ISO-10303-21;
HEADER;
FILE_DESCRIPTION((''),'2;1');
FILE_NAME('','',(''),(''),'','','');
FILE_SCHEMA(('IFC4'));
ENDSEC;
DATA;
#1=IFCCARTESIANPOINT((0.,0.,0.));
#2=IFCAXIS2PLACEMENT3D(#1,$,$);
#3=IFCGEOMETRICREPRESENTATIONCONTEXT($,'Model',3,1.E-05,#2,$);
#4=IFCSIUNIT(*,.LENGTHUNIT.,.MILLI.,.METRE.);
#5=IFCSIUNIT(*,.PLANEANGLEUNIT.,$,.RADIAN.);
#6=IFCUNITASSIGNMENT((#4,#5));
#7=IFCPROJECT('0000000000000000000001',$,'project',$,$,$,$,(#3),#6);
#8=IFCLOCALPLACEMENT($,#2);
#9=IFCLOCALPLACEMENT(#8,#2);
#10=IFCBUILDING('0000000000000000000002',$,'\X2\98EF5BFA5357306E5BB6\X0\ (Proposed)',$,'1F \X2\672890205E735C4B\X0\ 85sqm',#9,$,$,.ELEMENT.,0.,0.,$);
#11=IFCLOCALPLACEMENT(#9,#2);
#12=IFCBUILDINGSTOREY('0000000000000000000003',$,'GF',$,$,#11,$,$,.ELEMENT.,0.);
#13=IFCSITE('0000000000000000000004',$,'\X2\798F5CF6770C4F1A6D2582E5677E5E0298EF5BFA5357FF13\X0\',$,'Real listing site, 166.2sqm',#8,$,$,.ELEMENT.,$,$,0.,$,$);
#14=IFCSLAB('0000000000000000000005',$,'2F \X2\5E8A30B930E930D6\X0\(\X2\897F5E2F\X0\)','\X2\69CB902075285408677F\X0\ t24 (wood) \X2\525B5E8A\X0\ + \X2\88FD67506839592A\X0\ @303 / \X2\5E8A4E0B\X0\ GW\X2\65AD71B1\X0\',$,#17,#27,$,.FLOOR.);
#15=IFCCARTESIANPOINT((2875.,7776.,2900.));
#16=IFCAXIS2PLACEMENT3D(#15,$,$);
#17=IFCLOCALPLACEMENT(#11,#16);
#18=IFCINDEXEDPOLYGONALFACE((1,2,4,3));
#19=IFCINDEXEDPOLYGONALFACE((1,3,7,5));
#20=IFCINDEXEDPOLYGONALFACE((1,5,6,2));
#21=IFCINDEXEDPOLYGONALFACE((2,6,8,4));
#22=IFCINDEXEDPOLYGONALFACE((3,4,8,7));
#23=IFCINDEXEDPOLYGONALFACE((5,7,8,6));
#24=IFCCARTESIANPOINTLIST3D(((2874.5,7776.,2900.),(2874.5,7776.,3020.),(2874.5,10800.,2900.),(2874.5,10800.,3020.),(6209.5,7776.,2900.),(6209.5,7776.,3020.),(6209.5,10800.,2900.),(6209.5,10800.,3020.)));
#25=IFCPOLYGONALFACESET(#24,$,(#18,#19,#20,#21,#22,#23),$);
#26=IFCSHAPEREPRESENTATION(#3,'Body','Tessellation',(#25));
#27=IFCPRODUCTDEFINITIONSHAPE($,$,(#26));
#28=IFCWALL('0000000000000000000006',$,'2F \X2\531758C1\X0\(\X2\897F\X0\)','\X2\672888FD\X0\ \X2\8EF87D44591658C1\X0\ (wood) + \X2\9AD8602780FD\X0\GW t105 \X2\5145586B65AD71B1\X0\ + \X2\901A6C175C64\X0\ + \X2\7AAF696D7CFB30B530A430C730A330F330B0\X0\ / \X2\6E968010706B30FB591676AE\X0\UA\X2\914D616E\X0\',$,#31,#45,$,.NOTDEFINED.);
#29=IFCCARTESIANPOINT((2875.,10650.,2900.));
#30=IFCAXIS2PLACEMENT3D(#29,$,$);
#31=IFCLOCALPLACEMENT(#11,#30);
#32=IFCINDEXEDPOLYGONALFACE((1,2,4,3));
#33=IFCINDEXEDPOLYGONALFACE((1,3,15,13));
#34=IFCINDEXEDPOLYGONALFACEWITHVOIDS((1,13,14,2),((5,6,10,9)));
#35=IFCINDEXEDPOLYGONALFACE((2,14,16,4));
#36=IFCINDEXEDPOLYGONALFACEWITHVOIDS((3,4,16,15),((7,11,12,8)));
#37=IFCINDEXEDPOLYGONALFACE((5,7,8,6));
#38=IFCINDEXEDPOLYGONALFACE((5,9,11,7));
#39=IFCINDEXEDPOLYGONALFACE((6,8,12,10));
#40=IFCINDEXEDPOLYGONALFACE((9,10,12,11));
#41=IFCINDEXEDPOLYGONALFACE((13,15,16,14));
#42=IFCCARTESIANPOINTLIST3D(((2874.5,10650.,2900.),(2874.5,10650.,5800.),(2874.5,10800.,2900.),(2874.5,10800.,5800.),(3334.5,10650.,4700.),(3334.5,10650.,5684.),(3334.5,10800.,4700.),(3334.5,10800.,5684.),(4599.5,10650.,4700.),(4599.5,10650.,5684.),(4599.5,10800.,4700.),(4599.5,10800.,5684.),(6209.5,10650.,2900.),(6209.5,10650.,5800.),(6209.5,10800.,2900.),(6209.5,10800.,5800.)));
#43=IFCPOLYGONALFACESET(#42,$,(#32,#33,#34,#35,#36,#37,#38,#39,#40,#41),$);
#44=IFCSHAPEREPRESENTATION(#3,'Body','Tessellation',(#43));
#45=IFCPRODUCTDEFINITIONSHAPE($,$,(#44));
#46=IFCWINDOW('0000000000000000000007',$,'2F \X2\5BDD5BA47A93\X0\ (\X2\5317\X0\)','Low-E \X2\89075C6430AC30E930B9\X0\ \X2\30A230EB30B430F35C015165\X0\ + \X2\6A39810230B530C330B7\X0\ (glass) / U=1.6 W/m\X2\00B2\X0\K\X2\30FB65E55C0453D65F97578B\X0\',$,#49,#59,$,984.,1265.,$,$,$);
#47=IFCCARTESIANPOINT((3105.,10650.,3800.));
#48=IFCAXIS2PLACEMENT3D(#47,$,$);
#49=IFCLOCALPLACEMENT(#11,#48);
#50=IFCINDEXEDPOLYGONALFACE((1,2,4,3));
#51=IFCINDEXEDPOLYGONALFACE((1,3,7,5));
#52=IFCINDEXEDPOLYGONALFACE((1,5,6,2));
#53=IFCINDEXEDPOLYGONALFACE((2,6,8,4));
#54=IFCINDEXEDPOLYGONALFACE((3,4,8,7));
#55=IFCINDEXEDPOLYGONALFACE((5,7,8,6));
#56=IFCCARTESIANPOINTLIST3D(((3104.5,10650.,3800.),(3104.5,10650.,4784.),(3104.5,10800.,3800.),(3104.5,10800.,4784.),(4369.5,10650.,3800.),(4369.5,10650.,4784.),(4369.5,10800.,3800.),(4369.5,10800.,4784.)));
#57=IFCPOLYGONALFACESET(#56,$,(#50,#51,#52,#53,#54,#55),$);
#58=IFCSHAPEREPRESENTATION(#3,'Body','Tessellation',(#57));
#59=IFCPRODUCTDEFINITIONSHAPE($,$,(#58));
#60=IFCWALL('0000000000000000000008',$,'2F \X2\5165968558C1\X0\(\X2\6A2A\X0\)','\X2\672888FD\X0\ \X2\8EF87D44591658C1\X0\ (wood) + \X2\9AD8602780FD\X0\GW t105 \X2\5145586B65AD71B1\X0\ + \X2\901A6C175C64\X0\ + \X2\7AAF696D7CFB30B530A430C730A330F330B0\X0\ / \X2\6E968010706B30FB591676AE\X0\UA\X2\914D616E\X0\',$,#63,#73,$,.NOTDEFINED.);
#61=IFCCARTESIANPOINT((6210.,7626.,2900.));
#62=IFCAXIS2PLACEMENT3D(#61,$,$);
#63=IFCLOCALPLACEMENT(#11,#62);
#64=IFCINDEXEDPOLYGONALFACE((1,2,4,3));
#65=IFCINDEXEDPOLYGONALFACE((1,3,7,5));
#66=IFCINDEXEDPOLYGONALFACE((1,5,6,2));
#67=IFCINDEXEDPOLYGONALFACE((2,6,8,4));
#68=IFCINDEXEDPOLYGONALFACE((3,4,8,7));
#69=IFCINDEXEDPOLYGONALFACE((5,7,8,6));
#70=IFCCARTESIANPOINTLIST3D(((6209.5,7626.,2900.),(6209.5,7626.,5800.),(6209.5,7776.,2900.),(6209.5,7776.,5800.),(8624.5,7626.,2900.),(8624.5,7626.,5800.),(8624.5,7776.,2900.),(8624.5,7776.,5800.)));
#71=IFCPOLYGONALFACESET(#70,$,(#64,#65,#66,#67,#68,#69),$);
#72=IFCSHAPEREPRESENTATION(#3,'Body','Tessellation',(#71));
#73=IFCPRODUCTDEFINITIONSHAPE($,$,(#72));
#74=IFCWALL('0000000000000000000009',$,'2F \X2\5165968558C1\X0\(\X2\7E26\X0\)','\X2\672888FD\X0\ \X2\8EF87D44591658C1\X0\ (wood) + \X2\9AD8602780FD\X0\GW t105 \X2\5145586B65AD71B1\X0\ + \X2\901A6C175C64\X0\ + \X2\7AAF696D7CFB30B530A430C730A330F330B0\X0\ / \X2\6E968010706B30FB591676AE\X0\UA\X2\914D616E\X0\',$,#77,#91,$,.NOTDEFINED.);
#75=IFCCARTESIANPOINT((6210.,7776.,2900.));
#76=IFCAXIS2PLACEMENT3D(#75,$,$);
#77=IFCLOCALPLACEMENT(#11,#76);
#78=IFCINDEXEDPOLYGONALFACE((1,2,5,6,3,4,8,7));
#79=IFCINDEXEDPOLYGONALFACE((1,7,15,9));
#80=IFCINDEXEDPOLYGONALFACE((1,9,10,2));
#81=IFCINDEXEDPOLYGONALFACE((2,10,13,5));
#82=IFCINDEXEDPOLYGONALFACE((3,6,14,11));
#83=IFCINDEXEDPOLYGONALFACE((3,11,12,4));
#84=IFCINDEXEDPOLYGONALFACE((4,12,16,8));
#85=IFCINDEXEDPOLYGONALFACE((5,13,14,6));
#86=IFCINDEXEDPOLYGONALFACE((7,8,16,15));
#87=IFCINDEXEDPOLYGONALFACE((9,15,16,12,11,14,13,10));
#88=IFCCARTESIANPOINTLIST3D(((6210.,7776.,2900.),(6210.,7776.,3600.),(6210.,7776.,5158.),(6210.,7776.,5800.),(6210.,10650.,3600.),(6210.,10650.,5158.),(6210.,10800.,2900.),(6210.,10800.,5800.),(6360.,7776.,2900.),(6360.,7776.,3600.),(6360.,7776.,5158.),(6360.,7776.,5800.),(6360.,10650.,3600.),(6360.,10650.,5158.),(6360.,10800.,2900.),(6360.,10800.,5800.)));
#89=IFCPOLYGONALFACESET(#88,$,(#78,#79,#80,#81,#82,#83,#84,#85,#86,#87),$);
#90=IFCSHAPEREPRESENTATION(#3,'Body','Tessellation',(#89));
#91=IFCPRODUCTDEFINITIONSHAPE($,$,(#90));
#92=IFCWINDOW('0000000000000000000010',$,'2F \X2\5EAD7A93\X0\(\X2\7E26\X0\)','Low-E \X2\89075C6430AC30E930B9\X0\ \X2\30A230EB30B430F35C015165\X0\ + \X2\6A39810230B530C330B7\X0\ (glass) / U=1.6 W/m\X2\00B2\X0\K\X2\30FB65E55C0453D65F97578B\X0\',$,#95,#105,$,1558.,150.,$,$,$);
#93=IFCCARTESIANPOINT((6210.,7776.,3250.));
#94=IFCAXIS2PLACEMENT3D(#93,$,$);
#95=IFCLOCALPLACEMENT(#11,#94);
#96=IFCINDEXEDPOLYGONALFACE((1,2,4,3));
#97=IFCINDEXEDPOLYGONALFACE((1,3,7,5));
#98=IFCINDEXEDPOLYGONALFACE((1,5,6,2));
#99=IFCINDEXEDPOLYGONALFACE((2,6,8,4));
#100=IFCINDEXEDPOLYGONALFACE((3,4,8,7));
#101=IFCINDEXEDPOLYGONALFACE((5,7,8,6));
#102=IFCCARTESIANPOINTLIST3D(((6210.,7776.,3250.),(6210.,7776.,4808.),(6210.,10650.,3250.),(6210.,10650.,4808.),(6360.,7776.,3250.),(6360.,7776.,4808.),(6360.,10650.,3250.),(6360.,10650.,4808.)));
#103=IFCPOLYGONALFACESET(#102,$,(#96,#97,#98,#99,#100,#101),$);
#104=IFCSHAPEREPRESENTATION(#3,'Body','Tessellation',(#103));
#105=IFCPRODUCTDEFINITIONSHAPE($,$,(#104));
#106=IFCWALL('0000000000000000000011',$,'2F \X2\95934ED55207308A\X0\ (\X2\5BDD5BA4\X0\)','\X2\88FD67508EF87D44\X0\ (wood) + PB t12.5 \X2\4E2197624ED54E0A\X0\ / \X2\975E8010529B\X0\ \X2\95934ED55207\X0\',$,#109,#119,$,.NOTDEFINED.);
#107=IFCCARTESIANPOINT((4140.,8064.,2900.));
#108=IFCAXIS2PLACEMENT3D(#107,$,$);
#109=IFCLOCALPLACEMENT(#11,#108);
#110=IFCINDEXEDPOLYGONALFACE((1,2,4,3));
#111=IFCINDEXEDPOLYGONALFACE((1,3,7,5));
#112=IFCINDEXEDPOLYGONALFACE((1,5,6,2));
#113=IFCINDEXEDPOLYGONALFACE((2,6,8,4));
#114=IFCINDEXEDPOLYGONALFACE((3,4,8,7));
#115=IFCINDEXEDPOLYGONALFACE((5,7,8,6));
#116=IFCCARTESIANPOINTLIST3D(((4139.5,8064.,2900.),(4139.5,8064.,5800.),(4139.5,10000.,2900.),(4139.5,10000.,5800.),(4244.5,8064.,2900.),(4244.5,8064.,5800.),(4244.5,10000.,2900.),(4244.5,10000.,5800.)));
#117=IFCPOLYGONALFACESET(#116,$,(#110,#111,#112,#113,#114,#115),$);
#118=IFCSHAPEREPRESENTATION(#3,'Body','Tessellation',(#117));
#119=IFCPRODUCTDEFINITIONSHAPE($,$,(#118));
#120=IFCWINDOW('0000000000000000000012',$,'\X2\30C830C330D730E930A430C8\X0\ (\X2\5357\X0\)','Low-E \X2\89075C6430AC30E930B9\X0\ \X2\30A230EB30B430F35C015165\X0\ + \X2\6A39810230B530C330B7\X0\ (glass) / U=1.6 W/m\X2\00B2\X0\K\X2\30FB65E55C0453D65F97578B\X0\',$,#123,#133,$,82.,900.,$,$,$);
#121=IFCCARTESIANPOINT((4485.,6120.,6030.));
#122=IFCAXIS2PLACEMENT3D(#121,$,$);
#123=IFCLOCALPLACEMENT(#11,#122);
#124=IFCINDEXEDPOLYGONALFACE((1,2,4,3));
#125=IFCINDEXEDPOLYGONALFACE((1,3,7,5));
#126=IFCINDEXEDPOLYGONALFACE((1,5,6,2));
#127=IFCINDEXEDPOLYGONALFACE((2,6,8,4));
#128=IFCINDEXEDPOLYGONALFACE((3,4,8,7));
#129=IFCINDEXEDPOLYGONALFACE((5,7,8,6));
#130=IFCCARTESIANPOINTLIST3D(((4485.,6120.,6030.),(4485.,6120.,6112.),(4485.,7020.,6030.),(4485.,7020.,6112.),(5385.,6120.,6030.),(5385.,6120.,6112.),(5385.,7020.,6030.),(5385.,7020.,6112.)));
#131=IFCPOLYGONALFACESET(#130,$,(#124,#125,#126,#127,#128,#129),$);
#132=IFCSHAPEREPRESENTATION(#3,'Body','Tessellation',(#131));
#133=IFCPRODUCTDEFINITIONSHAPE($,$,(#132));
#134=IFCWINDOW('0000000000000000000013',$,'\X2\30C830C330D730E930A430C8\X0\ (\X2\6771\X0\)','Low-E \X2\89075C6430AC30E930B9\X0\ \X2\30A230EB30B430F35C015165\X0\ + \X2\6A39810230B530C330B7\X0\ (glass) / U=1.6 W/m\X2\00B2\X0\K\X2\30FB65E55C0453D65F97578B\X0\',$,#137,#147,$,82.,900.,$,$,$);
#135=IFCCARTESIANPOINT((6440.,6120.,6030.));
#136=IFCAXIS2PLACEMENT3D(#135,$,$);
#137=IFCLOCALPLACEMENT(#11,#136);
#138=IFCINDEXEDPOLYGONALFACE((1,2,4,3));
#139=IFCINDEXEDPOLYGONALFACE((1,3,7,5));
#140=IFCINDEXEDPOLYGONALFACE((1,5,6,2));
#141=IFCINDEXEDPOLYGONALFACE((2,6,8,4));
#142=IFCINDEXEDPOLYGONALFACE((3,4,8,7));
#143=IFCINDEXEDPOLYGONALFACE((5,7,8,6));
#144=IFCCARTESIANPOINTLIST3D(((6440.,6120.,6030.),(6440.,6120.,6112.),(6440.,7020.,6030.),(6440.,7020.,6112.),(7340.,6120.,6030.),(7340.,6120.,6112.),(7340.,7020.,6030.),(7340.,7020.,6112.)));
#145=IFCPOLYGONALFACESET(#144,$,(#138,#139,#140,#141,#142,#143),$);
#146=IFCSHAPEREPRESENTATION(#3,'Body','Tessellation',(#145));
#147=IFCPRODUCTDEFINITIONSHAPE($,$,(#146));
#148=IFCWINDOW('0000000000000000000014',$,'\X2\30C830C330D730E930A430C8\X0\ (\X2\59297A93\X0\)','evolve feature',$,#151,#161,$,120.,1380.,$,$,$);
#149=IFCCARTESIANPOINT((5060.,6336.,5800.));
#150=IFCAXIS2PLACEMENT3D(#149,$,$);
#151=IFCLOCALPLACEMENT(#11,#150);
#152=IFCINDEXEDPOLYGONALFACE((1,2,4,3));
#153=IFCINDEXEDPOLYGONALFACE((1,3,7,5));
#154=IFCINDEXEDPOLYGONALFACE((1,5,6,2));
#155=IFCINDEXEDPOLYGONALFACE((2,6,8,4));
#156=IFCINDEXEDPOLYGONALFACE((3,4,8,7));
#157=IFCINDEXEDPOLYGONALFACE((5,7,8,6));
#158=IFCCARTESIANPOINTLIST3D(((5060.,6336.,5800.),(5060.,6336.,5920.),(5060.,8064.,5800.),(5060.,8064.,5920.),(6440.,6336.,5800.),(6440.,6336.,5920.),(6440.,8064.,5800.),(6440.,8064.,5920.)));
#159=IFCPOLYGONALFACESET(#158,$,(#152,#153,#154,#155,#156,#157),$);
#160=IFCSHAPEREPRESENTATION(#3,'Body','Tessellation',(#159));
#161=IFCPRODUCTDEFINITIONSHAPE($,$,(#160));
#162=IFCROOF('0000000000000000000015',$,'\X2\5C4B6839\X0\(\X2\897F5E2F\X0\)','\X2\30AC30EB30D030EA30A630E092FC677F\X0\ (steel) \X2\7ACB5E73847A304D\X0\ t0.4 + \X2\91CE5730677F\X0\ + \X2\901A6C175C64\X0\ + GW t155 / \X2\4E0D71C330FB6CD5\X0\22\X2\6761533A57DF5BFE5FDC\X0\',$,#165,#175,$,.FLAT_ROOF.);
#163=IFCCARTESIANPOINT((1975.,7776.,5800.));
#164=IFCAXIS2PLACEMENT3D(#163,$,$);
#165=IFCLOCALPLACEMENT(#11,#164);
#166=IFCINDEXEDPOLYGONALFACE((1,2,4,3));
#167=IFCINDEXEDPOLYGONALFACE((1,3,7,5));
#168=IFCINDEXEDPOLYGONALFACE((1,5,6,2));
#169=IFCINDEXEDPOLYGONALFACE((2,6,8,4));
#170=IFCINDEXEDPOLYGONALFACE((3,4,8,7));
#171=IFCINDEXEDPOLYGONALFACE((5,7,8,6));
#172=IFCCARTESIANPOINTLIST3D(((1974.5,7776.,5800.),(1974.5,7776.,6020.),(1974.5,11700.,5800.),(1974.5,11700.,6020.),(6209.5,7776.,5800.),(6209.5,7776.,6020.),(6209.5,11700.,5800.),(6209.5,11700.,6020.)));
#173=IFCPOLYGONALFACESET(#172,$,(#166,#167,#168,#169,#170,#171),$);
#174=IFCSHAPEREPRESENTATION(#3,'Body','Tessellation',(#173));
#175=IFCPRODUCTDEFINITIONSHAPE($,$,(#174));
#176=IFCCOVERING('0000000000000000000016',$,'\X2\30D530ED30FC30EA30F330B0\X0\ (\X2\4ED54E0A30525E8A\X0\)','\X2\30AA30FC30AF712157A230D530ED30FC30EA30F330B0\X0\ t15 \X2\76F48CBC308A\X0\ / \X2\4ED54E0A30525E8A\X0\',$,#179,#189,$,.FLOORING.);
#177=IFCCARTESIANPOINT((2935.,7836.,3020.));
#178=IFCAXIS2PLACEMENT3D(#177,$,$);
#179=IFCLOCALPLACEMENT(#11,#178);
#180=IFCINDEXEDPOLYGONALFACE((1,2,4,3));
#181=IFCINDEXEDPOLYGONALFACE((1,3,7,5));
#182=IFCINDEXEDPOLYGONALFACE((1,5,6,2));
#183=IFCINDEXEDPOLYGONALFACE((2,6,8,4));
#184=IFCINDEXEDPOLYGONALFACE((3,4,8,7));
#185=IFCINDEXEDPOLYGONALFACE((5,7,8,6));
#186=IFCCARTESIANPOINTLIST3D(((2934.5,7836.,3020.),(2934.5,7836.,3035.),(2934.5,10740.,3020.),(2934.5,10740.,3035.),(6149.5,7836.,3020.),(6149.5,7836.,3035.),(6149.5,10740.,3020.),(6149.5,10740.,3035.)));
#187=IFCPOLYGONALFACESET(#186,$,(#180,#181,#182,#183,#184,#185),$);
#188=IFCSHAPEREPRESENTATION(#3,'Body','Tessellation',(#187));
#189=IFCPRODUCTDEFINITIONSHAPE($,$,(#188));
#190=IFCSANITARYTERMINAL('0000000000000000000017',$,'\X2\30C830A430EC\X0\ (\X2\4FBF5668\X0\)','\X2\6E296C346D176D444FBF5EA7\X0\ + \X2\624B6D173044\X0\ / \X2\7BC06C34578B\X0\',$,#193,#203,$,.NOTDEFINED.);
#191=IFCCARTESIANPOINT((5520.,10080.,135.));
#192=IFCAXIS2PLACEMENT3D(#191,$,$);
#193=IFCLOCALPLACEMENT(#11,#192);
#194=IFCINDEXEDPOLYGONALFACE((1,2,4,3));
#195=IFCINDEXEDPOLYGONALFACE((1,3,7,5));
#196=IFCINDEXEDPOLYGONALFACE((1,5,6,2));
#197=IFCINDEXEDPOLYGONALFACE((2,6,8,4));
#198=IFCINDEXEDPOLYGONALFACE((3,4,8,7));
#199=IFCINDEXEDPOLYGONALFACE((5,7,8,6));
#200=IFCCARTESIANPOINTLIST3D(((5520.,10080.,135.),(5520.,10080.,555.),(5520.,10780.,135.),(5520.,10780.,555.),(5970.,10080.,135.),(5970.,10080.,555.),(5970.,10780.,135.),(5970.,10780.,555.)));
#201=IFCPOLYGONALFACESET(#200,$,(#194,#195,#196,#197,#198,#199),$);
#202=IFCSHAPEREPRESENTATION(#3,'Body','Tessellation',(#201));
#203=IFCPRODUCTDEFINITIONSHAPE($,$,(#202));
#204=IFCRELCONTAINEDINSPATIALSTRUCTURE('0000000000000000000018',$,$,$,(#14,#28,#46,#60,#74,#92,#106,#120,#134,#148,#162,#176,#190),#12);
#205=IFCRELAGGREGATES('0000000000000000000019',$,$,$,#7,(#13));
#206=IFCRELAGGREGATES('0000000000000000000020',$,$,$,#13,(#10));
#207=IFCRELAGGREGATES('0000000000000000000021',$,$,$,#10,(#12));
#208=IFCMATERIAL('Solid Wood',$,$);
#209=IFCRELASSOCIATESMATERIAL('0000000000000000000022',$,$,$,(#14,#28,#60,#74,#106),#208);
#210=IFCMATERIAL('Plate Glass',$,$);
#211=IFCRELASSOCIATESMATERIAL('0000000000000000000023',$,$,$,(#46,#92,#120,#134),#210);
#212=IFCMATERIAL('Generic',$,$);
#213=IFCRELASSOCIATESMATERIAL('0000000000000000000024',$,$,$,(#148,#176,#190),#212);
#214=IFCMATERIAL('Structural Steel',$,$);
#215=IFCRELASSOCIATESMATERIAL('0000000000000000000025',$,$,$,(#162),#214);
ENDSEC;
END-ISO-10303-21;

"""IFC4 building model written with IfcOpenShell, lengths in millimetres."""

from ifc_helpers import new_model, si_unit, frame, frame_2d, origin, place, context, project, spatial, rectangle, extrude, material, element, fill, save


model = new_model("IFC4")

# Units and contexts
model_context = context("Model", 3, precision=1e-05, world=origin())
ifc_project = project(units=[si_unit("LENGTHUNIT", "METRE", prefix="MILLI"), si_unit("PLANEANGLEUNIT", "RADIAN")], contexts=[model_context])

# Site, building, storey
site_placement = place(None, origin())
site = spatial("IfcSite", under=ifc_project, at=site_placement, Name="福島県会津若松市飯寺南３", ObjectType="Real listing site, 166.2sqm", CompositionType="ELEMENT", RefElevation=0.0)
building_placement = place(site_placement, origin())
building = spatial("IfcBuilding", under=site, at=building_placement, Name="飯寺南の家 (Proposed)", ObjectType="1F 木造平屋 85sqm", CompositionType="ELEMENT", ElevationOfRefHeight=0.0, ElevationOfTerrain=0.0)
storey_placement = place(building_placement, origin())
storey = spatial("IfcBuildingStorey", under=building, at=storey_placement, Name="GF", CompositionType="ELEMENT", Elevation=0.0)

# Slab
ifc_material_1 = material(Name="Solid Wood")
slab_placement = place(storey_placement, frame((2875.0, 7776.0, 2900.0)))
element("IfcSlab", 1, at=slab_placement, inside=storey, material=ifc_material_1, Name="2F 床スラブ(西帯)", Description="構造用合板 t24 (wood) 剛床 + 製材根太 @303 / 床下 GW断熱", PredefinedType="FLOOR", context=model_context, shape_type="SweptSolid", body=[
    extrude(rectangle(XDim=3335.0, YDim=3024.0, at=frame_2d((1667.0, 1512.0))), frame((2875.0, 7776.0, 2900.0)), (0.0, 0.0, 1.0), 120.0),
])

# Wall, opening, window
wall_1_placement = place(storey_placement, frame((2875.0, 10650.0, 2900.0)))
wall_1 = element("IfcWall", 2, at=wall_1_placement, inside=storey, material=ifc_material_1, Name="2F 北壁(西)", Description="木製 軸組外壁 (wood) + 高性能GW t105 充填断熱 + 通気層 + 窯業系サイディング / 準耐火・外皮UA配慮", PredefinedType="NOTDEFINED", context=model_context, shape_type="SweptSolid", body=[
    extrude(rectangle(XDim=3335.0, YDim=150.0, at=frame_2d((1667.0, 75.0))), frame((2875.0, 10650.0, 2900.0)), (0.0, 0.0, 1.0), 2900.0),
])
opening_1_placement = place(storey_placement, frame((3105.0, 10650.0, 3800.0)))
opening_1 = element("IfcOpeningElement", 3, at=opening_1_placement, cuts=wall_1, PredefinedType="NOTDEFINED", context=model_context, shape_type="SweptSolid", body=[
    extrude(rectangle(XDim=1265.0, YDim=150.0, at=frame_2d((632.0, 75.0))), frame((3105.0, 10650.0, 3800.0)), (0.0, 0.0, 1.0), 984.0),
])
ifc_material_2 = material(Name="Plate Glass")
window_1_placement = place(storey_placement, frame((3105.0, 10650.0, 3800.0)))
window_1 = element("IfcWindow", 4, at=window_1_placement, inside=storey, material=ifc_material_2, Name="2F 寝室窓 (北)", Description="Low-E 複層ガラス アルゴン封入 + 樹脂サッシ (glass) / U=1.6 W/m²K・日射取得型", OverallHeight=984.0, OverallWidth=1265.0, context=model_context, shape_type="SweptSolid", body=[
    extrude(rectangle(XDim=1265.0, YDim=150.0, at=frame_2d((632.0, 75.0))), frame((3105.0, 10650.0, 3800.0)), (0.0, 0.0, 1.0), 984.0),
])
fill(opening_1, window_1)

# Wall
wall_2_placement = place(storey_placement, frame((6210.0, 7626.0, 2900.0)))
element("IfcWall", 5, at=wall_2_placement, inside=storey, material=ifc_material_1, Name="2F 入隅壁(横)", Description="木製 軸組外壁 (wood) + 高性能GW t105 充填断熱 + 通気層 + 窯業系サイディング / 準耐火・外皮UA配慮", PredefinedType="NOTDEFINED", context=model_context, shape_type="SweptSolid", body=[
    extrude(rectangle(XDim=2415.0, YDim=150.0, at=frame_2d((1207.0, 75.0))), frame((6210.0, 7626.0, 2900.0)), (0.0, 0.0, 1.0), 2900.0),
])

# Wall, opening, window
wall_3_placement = place(storey_placement, frame((6210.0, 7776.0, 2900.0)))
wall_3 = element("IfcWall", 6, at=wall_3_placement, inside=storey, material=ifc_material_1, Name="2F 入隅壁(縦)", Description="木製 軸組外壁 (wood) + 高性能GW t105 充填断熱 + 通気層 + 窯業系サイディング / 準耐火・外皮UA配慮", PredefinedType="NOTDEFINED", context=model_context, shape_type="SweptSolid", body=[
    extrude(rectangle(XDim=150.0, YDim=3024.0, at=frame_2d((75.0, 1512.0))), frame((6210.0, 7776.0, 2900.0)), (0.0, 0.0, 1.0), 2900.0),
])
opening_2_placement = place(storey_placement, frame((6210.0, 7776.0, 3250.0)))
opening_2 = element("IfcOpeningElement", 7, at=opening_2_placement, cuts=wall_3, PredefinedType="NOTDEFINED", context=model_context, shape_type="SweptSolid", body=[
    extrude(rectangle(XDim=150.0, YDim=2874.0, at=frame_2d((75.0, 1437.0))), frame((6210.0, 7776.0, 3250.0)), (0.0, 0.0, 1.0), 1558.0),
])
window_2_placement = place(storey_placement, frame((6210.0, 7776.0, 3250.0)))
window_2 = element("IfcWindow", 8, at=window_2_placement, inside=storey, material=ifc_material_2, Name="2F 庭窓(縦)", Description="Low-E 複層ガラス アルゴン封入 + 樹脂サッシ (glass) / U=1.6 W/m²K・日射取得型", OverallHeight=1558.0, OverallWidth=150.0, context=model_context, shape_type="SweptSolid", body=[
    extrude(rectangle(XDim=150.0, YDim=2874.0, at=frame_2d((75.0, 1437.0))), frame((6210.0, 7776.0, 3250.0)), (0.0, 0.0, 1.0), 1558.0),
])
fill(opening_2, window_2)

# Wall
wall_4_placement = place(storey_placement, frame((4140.0, 8064.0, 2900.0)))
element("IfcWall", 9, at=wall_4_placement, inside=storey, material=ifc_material_1, Name="2F 間仕切り (寝室)", Description="製材軸組 (wood) + PB t12.5 両面仕上 / 非耐力 間仕切", PredefinedType="NOTDEFINED", context=model_context, shape_type="SweptSolid", body=[
    extrude(rectangle(XDim=105.0, YDim=1936.0, at=frame_2d((52.0, 968.0))), frame((4140.0, 8064.0, 2900.0)), (0.0, 0.0, 1.0), 2900.0),
])

# Windows
window_3_placement = place(storey_placement, frame((4485.0, 6120.0, 6030.0)))
element("IfcWindow", 10, at=window_3_placement, inside=storey, material=ifc_material_2, Name="トップライト (南)", Description="Low-E 複層ガラス アルゴン封入 + 樹脂サッシ (glass) / U=1.6 W/m²K・日射取得型", OverallHeight=82.0, OverallWidth=900.0, context=model_context, shape_type="SweptSolid", body=[
    extrude(rectangle(XDim=900.0, YDim=900.0, at=frame_2d((450.0, 450.0))), frame((4485.0, 6120.0, 6030.0)), (0.0, 0.0, 1.0), 82.0),
])
window_4_placement = place(storey_placement, frame((6440.0, 6120.0, 6030.0)))
element("IfcWindow", 11, at=window_4_placement, inside=storey, material=ifc_material_2, Name="トップライト (東)", Description="Low-E 複層ガラス アルゴン封入 + 樹脂サッシ (glass) / U=1.6 W/m²K・日射取得型", OverallHeight=82.0, OverallWidth=900.0, context=model_context, shape_type="SweptSolid", body=[
    extrude(rectangle(XDim=900.0, YDim=900.0, at=frame_2d((450.0, 450.0))), frame((6440.0, 6120.0, 6030.0)), (0.0, 0.0, 1.0), 82.0),
])
ifc_material_3 = material(Name="Generic")
window_5_placement = place(storey_placement, frame((5060.0, 6336.0, 5800.0)))
element("IfcWindow", 12, at=window_5_placement, inside=storey, material=ifc_material_3, Name="トップライト (天窓)", Description="evolve feature", OverallHeight=120.0, OverallWidth=1380.0, context=model_context, shape_type="SweptSolid", body=[
    extrude(rectangle(XDim=1380.0, YDim=1728.0, at=frame_2d((690.0, 864.0))), frame((5060.0, 6336.0, 5800.0)), (0.0, 0.0, 1.0), 120.0),
])

# Roof
ifc_material_4 = material(Name="Structural Steel")
for number, where, name in (
    (13, (1975.0, 7776.0, 5800.0), "屋根(西帯)"),
):
    element("IfcRoof", number, at=place(storey_placement, frame(where)), inside=storey, material=ifc_material_4, Name=name, Description="ガルバリウム鋼板 (steel) 立平葺き t0.4 + 野地板 + 通気層 + GW t155 / 不燃・法22条区域対応", PredefinedType="FLAT_ROOF", context=model_context, shape_type="SweptSolid", body=[
        extrude(rectangle(XDim=4235.0, YDim=3924.0, at=frame_2d((2117.0, 1962.0))), frame((1975.0, 7776.0, 5800.0)), (0.0, 0.0, 1.0), 220.0),
    ])

# Covering
covering_placement = place(storey_placement, frame((2935.0, 7836.0, 3020.0)))
element("IfcCovering", 14, at=covering_placement, inside=storey, material=ifc_material_3, Name="フローリング (仕上げ床)", Description="オーク無垢フローリング t15 直貼り / 仕上げ床", PredefinedType="FLOORING", context=model_context, shape_type="SweptSolid", body=[
    extrude(rectangle(XDim=3215.0, YDim=2904.0, at=frame_2d((1607.0, 1452.0))), frame((2935.0, 7836.0, 3020.0)), (0.0, 0.0, 1.0), 15.0),
])

# Sanitary terminal
sanitary_terminal_placement = place(storey_placement, frame((5520.0, 10080.0, 135.0)))
element("IfcSanitaryTerminal", 15, at=sanitary_terminal_placement, inside=storey, material=ifc_material_3, Name="トイレ (便器)", Description="温水洗浄便座 + 手洗い / 節水型", PredefinedType="NOTDEFINED", context=model_context, shape_type="SweptSolid", body=[
    extrude(rectangle(XDim=450.0, YDim=700.0, at=frame_2d((225.0, 350.0))), frame((5520.0, 10080.0, 135.0)), (0.0, 0.0, 1.0), 420.0),
])

save(model, "model.ifc")
